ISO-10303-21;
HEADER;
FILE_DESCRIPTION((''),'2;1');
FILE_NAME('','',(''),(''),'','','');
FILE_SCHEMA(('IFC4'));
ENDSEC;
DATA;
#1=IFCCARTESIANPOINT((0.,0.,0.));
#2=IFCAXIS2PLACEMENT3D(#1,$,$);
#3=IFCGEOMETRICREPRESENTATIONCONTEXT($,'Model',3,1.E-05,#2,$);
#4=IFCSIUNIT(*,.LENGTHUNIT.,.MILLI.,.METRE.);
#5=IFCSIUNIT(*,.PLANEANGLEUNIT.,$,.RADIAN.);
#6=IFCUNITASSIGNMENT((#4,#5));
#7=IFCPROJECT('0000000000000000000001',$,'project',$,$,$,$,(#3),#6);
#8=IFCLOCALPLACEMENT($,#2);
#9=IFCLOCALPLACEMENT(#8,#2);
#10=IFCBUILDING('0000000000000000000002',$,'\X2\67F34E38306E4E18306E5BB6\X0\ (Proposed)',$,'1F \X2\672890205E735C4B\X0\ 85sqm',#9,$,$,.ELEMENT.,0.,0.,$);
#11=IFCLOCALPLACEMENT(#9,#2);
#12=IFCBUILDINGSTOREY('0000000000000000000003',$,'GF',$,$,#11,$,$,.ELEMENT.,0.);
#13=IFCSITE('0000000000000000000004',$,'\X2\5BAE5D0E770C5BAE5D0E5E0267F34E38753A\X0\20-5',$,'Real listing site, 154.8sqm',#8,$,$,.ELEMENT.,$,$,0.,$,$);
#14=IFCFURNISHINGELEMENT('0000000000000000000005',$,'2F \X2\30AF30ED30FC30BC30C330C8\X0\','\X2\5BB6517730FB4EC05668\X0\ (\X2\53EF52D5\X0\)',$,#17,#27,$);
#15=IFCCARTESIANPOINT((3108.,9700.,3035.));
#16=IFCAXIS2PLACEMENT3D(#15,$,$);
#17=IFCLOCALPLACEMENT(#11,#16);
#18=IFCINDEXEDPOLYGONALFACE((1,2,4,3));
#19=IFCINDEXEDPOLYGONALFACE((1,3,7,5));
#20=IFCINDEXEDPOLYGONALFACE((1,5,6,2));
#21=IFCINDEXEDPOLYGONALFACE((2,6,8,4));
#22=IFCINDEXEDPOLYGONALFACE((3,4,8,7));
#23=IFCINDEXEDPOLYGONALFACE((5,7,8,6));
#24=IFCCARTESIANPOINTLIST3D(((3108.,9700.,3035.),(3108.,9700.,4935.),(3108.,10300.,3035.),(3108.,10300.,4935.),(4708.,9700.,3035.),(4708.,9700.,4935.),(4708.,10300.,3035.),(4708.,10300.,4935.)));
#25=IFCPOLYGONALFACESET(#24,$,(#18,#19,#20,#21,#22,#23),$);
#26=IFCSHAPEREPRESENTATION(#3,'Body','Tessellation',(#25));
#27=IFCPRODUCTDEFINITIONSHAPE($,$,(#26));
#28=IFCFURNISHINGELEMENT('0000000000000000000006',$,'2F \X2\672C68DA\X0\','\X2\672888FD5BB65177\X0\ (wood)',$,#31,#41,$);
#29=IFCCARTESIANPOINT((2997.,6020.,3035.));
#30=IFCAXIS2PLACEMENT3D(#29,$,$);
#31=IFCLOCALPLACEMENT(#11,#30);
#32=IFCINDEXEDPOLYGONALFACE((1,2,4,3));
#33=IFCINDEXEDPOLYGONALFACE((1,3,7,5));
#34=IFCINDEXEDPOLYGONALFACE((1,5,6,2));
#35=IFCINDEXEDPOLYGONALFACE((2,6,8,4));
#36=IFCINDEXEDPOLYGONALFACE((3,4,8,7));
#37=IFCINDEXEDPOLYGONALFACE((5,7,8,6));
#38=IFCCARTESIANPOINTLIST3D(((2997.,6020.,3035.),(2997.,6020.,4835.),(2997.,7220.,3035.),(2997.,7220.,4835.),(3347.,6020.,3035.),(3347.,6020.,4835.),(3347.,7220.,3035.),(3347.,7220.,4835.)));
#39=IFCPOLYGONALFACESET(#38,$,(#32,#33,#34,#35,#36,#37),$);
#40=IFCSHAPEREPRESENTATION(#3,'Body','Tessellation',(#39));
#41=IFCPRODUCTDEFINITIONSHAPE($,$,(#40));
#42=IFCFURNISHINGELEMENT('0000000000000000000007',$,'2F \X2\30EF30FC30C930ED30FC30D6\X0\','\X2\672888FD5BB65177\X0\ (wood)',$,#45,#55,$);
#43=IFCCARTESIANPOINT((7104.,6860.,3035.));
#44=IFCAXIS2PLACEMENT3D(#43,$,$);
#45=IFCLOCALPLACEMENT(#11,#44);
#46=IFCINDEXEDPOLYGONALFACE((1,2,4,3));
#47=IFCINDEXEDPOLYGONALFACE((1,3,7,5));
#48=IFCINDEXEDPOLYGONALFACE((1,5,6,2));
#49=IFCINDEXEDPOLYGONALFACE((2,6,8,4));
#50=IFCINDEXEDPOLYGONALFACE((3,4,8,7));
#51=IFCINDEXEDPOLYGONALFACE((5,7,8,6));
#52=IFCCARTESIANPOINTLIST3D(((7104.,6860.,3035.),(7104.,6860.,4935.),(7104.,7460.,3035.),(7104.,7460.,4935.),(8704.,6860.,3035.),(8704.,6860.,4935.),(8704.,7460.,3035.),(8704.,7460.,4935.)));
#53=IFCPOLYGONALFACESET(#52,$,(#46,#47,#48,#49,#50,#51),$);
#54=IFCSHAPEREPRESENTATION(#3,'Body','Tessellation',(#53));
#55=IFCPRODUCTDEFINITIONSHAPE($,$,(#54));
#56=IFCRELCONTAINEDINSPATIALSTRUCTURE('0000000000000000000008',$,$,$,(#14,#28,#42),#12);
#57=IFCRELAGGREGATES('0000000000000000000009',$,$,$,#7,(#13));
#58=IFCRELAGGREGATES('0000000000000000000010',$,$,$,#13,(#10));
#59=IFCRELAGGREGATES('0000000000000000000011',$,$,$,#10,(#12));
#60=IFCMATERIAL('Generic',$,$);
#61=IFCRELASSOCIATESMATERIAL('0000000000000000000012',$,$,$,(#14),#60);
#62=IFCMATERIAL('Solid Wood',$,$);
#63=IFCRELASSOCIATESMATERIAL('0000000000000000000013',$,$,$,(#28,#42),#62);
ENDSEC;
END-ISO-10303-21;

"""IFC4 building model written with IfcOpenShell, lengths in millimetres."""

from ifc_helpers import new_model, si_unit, frame, frame_2d, origin, place, context, project, spatial, rectangle, extrude, material, element, save


model = new_model("IFC4")

# Units and contexts
model_context = context("Model", 3, precision=1e-05, world=origin())
ifc_project = project(units=[si_unit("LENGTHUNIT", "METRE", prefix="MILLI"), si_unit("PLANEANGLEUNIT", "RADIAN")], contexts=[model_context])

# Site, building, storey
site_placement = place(None, origin())
site = spatial("IfcSite", under=ifc_project, at=site_placement, Name="宮崎県宮崎市柳丸町20-5", ObjectType="Real listing site, 154.8sqm", CompositionType="ELEMENT", RefElevation=0.0)
building_placement = place(site_placement, origin())
building = spatial("IfcBuilding", under=site, at=building_placement, Name="柳丸の丘の家 (Proposed)", ObjectType="1F 木造平屋 85sqm", CompositionType="ELEMENT", ElevationOfRefHeight=0.0, ElevationOfTerrain=0.0)
storey_placement = place(building_placement, origin())
storey = spatial("IfcBuildingStorey", under=building, at=storey_placement, Name="GF", CompositionType="ELEMENT", Elevation=0.0)

# Shared definitions
ifc_material_1 = material(Name="Solid Wood")

# Shared definitions
ifc_material_2 = material(Name="Generic")

# Furnishing elements
furnishing_1_placement = place(storey_placement, frame((3108.0, 9700.0, 3035.0)))
element("IfcFurnishingElement", 1, at=furnishing_1_placement, inside=storey, material=ifc_material_2, Name="2F クローゼット", Description="家具・什器 (可動)", context=model_context, shape_type="SweptSolid", body=[
    extrude(rectangle(XDim=1600.0, YDim=600.0, at=frame_2d((800.0, 300.0))), frame((3108.0, 9700.0, 3035.0)), (0.0, 0.0, 1.0), 1900.0),
])
furnishing_2_placement = place(storey_placement, frame((2997.0, 6020.0, 3035.0)))
element("IfcFurnishingElement", 2, at=furnishing_2_placement, inside=storey, material=ifc_material_1, Name="2F 本棚", Description="木製家具 (wood)", context=model_context, shape_type="SweptSolid", body=[
    extrude(rectangle(XDim=350.0, YDim=1200.0, at=frame_2d((175.0, 600.0))), frame((2997.0, 6020.0, 3035.0)), (0.0, 0.0, 1.0), 1800.0),
])
furnishing_3_placement = place(storey_placement, frame((7104.0, 6860.0, 3035.0)))
element("IfcFurnishingElement", 3, at=furnishing_3_placement, inside=storey, material=ifc_material_1, Name="2F ワードローブ", Description="木製家具 (wood)", context=model_context, shape_type="SweptSolid", body=[
    extrude(rectangle(XDim=1600.0, YDim=600.0, at=frame_2d((800.0, 300.0))), frame((7104.0, 6860.0, 3035.0)), (0.0, 0.0, 1.0), 1900.0),
])

save(model, "model.ifc")
